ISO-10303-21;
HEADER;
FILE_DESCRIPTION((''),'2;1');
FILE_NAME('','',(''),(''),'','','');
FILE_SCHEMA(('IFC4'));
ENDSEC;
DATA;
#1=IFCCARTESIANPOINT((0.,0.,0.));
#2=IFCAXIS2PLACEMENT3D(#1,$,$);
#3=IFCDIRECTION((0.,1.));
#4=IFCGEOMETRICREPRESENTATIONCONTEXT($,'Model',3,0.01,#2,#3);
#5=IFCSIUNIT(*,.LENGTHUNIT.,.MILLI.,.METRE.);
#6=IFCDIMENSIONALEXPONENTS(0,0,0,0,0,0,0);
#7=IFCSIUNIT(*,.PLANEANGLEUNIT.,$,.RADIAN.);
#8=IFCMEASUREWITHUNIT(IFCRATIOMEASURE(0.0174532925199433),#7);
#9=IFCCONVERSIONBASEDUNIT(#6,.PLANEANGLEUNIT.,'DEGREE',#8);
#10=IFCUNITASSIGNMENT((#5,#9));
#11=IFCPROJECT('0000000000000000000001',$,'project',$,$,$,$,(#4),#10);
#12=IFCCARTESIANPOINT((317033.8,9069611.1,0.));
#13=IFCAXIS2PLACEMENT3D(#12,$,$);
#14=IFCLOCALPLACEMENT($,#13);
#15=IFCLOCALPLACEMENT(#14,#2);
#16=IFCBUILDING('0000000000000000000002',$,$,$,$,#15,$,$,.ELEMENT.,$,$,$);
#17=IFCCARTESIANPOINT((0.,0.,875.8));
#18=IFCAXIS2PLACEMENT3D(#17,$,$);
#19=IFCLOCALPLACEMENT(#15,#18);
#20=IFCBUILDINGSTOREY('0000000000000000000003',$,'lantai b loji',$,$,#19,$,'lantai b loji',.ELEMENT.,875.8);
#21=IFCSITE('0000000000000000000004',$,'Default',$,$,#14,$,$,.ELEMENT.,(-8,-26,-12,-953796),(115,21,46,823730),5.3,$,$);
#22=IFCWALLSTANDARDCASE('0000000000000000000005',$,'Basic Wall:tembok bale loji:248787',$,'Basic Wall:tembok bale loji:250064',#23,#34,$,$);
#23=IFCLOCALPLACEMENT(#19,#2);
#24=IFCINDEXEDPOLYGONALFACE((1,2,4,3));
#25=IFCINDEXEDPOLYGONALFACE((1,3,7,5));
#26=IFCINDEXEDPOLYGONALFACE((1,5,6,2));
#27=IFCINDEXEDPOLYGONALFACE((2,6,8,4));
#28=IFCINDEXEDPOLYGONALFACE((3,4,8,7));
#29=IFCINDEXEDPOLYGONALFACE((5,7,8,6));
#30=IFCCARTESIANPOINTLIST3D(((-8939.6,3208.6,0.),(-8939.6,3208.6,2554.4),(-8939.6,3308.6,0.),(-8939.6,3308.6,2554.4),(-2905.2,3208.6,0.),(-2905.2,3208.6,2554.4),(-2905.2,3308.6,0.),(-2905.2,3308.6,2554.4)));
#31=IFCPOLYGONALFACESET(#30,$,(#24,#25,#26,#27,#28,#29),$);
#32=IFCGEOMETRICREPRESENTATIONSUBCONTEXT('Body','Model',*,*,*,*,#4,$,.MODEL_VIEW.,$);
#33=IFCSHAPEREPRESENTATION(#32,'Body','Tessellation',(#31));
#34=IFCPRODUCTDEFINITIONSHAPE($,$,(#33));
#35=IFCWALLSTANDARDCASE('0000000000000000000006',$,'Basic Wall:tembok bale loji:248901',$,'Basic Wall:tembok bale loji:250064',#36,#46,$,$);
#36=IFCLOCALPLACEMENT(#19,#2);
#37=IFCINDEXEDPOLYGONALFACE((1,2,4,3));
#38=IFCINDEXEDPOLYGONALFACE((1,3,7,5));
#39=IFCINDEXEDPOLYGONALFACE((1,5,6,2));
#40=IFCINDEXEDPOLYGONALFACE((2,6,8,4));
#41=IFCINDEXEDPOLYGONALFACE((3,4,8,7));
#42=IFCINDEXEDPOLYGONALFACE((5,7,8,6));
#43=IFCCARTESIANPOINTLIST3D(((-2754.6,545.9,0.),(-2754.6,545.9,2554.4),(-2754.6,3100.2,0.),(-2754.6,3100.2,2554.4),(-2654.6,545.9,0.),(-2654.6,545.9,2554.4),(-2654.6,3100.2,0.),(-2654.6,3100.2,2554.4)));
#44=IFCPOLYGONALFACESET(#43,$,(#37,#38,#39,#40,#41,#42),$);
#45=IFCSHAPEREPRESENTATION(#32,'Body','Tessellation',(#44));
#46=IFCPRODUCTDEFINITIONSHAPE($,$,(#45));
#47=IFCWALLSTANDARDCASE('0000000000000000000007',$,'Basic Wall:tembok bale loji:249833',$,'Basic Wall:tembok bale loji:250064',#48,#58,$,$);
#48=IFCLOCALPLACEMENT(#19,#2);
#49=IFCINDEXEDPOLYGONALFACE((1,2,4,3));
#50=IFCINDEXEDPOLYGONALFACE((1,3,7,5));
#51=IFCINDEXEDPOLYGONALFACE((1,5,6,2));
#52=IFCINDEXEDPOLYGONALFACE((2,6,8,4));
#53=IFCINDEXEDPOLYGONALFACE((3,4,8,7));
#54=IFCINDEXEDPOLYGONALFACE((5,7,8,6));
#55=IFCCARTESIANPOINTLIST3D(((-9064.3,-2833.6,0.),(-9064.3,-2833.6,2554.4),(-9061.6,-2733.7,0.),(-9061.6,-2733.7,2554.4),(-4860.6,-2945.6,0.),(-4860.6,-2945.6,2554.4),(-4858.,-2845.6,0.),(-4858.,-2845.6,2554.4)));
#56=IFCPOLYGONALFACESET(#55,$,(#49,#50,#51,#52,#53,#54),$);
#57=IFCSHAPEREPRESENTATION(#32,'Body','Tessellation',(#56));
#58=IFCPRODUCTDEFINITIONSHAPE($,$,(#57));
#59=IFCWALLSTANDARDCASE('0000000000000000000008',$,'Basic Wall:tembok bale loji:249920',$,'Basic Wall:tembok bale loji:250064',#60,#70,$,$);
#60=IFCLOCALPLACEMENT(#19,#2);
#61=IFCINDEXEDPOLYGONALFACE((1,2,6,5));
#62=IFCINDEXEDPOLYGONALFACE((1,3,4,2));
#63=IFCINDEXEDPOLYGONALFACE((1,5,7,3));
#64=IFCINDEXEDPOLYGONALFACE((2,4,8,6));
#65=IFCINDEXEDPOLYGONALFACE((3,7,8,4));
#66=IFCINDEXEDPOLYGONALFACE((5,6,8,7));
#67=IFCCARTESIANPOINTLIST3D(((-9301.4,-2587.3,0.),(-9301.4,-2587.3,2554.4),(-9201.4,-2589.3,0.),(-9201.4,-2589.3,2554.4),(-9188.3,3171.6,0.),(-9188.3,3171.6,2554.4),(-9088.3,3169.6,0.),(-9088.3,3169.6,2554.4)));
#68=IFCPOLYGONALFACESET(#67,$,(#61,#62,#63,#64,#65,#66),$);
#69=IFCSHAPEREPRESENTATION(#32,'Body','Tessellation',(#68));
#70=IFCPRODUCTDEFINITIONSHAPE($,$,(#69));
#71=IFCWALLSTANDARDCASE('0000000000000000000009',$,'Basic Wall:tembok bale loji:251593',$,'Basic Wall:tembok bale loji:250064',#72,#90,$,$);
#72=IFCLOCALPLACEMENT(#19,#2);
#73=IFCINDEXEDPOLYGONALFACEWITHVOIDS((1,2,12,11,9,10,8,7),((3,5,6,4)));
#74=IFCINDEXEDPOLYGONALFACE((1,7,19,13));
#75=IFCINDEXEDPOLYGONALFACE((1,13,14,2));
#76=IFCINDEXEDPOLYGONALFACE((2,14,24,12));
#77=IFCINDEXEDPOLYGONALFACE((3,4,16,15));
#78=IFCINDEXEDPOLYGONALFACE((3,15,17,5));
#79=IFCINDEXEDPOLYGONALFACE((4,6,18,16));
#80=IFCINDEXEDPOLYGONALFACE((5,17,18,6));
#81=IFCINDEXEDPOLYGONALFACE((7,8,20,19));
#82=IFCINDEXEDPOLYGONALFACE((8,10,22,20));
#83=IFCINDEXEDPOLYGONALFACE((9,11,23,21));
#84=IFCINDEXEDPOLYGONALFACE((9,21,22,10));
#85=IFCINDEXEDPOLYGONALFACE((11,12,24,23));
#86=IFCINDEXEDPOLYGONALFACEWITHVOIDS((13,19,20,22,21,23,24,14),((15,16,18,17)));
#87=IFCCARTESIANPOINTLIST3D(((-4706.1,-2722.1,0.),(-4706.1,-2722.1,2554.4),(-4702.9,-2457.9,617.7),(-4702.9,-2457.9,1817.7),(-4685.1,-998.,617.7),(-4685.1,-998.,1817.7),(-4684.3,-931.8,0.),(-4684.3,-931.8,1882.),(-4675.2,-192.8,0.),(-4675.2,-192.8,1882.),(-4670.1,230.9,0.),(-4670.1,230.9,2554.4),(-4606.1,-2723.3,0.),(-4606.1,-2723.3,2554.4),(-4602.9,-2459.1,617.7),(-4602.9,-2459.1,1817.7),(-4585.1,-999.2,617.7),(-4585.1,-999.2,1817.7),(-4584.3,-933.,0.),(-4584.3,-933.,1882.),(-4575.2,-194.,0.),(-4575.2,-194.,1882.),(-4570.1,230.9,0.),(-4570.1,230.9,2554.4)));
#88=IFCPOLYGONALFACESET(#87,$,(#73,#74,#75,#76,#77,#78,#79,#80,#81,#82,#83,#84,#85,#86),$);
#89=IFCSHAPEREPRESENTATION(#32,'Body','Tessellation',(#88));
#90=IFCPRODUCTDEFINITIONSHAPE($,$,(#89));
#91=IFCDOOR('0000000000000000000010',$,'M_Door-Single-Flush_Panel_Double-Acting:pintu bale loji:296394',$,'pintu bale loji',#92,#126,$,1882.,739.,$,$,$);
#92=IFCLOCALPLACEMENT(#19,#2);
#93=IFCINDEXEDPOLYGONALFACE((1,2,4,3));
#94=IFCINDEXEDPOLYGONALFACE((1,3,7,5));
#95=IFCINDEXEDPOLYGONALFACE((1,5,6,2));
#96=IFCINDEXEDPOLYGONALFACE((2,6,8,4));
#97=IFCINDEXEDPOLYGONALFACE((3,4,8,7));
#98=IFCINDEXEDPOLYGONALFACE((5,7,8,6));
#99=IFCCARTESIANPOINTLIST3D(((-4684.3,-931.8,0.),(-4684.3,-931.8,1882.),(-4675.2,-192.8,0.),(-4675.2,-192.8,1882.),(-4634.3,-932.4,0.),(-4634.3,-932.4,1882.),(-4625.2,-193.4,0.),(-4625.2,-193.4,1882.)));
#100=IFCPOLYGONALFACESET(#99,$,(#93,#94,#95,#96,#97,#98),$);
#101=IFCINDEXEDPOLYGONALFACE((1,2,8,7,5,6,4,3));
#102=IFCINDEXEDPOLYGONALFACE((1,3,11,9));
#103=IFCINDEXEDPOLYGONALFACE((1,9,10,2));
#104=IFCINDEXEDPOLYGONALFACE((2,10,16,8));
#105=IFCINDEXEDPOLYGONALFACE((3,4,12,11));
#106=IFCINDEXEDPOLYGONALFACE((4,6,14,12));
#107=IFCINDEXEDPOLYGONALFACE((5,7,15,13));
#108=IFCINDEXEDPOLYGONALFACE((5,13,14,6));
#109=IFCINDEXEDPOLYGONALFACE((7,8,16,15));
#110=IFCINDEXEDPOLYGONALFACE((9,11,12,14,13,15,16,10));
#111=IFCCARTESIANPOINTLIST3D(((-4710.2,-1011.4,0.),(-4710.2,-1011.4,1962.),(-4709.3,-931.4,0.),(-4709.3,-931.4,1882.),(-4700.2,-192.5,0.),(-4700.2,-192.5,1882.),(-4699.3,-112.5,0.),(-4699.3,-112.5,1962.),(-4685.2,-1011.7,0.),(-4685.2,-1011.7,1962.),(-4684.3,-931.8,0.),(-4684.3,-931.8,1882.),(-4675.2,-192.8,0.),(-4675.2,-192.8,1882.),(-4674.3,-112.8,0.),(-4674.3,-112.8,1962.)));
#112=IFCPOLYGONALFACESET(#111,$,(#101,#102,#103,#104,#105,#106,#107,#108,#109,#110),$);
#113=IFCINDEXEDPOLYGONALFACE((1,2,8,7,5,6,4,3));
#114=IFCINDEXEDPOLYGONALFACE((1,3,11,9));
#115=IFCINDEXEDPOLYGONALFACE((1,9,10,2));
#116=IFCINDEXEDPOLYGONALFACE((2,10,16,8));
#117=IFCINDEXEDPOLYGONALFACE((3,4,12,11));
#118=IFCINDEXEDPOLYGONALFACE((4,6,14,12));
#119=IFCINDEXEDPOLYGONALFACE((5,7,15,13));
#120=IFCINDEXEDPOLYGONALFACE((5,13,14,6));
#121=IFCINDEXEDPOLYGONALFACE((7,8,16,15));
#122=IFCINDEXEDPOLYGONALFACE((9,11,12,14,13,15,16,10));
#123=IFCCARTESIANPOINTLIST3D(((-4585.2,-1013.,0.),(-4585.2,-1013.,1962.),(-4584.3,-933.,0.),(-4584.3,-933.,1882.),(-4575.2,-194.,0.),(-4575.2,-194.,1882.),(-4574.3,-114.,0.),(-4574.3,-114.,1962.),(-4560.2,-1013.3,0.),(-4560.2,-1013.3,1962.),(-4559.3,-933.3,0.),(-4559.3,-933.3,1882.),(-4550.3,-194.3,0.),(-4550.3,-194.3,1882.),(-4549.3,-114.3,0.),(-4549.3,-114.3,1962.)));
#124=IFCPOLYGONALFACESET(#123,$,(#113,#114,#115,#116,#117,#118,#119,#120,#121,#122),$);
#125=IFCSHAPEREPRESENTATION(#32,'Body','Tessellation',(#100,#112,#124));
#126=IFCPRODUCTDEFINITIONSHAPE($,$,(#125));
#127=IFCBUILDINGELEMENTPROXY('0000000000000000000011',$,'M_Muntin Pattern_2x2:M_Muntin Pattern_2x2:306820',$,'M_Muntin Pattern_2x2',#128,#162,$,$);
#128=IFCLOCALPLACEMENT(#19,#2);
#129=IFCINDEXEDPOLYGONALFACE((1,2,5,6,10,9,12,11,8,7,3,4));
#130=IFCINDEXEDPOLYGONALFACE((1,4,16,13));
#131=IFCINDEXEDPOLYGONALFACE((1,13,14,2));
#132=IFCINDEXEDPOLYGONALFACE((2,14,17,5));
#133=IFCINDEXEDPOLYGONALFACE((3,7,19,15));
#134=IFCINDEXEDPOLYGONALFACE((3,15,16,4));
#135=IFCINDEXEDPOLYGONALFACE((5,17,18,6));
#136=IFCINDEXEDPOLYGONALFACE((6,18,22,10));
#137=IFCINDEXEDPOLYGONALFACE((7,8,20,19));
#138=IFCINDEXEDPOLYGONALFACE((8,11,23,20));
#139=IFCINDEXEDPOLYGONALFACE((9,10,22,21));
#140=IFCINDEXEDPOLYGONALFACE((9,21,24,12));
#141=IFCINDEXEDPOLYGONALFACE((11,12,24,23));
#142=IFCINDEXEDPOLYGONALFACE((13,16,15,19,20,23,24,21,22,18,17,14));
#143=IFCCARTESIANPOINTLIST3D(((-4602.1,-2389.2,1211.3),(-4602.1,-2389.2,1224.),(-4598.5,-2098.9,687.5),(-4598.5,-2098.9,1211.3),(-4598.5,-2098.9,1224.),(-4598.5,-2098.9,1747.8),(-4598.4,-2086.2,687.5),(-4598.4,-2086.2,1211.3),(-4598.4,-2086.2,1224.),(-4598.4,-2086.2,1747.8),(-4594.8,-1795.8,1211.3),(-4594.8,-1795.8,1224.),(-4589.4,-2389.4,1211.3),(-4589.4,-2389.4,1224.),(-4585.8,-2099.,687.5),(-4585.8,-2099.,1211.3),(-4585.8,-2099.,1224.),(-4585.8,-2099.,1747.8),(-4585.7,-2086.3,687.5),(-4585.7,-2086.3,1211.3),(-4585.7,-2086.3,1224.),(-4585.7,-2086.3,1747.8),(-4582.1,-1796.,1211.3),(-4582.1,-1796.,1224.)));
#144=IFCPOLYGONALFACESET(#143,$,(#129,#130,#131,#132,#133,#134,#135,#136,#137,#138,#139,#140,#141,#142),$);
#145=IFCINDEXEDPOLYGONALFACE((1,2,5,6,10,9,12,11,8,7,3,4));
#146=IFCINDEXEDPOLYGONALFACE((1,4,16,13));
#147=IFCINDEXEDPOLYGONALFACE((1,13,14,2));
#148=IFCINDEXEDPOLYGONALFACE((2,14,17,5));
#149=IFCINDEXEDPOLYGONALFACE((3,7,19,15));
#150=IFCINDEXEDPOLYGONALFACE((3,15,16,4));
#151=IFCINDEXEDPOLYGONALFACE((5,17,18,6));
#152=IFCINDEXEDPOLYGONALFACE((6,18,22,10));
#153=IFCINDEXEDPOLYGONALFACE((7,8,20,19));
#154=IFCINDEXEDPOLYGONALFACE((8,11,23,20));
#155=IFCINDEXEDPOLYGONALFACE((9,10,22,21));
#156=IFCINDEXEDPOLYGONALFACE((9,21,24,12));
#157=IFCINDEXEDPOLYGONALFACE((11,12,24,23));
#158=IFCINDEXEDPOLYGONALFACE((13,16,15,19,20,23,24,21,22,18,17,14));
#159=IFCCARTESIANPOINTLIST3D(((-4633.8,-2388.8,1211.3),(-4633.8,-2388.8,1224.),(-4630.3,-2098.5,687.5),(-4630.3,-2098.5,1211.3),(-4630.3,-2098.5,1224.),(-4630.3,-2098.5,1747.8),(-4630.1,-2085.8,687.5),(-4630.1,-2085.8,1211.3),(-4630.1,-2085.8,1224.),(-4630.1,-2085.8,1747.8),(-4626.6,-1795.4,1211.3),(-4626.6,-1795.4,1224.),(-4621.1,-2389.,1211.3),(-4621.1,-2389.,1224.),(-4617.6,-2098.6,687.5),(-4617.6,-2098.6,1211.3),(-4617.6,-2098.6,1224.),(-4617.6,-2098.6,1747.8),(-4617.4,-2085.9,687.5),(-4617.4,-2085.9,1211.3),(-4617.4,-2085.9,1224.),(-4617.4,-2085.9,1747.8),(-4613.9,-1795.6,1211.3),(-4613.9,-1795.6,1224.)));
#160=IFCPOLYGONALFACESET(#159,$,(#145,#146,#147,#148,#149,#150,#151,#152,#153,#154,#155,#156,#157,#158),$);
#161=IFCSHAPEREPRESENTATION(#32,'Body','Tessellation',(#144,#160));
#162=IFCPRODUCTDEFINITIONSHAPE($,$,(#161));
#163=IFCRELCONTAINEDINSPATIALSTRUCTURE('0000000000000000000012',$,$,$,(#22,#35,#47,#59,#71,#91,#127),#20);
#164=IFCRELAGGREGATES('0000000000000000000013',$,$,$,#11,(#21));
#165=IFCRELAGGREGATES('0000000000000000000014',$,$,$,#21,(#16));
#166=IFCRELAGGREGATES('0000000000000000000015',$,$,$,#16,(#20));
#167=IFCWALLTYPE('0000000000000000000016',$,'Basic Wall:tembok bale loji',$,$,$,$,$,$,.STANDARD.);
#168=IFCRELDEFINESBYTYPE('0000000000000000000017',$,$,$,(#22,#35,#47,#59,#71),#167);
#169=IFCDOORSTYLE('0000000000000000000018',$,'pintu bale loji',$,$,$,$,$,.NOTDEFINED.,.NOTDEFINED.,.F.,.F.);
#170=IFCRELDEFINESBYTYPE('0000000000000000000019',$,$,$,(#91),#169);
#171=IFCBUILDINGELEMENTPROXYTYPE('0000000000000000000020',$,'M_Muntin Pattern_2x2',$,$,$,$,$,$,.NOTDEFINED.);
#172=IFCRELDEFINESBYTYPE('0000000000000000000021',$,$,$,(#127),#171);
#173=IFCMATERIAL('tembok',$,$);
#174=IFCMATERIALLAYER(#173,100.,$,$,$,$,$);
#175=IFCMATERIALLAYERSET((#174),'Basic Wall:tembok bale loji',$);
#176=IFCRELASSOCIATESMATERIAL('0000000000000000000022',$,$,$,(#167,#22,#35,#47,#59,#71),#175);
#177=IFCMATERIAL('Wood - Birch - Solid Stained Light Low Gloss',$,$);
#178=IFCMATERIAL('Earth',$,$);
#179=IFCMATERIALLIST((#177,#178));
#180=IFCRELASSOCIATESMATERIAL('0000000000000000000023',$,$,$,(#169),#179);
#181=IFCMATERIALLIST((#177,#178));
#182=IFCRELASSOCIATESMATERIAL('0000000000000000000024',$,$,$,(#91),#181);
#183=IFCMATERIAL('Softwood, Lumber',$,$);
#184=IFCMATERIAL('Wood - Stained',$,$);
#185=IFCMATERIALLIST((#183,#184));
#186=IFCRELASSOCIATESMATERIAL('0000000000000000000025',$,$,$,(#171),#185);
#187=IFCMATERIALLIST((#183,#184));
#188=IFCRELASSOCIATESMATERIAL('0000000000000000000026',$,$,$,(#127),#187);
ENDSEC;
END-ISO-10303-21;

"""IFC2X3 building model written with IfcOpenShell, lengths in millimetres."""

from ifc_helpers import new_model, entity, si_unit, converted_unit, direction, frame, frame_2d, origin, place, context, subcontext, project, spatial, polyline, rectangle, outline, extrude, source, transform, mapped, material, material_list, layer, layer_set, layer_usage, type_object, type_shapes, element, fill, save


model = new_model("IFC2X3")

# Units and contexts
model_context = context("Model", 3, precision=0.01, world=origin(), true_north=direction((0.0, 1.0)))
body_context = subcontext(model_context, "Body", "Model", "MODEL_VIEW")
ifc_project = project(units=[si_unit("LENGTHUNIT", "METRE", prefix="MILLI"), converted_unit("PLANEANGLEUNIT", "DEGREE", entity("IfcRatioMeasure", 0.0174532925199433), si_unit("PLANEANGLEUNIT", "RADIAN"), dimensions=[0, 0, 0, 0, 0, 0, 0])], contexts=[model_context])

# Site, building, storey
site_placement = place(None, frame((317033.8, 9069611.1, 0.0)))
site = spatial("IfcSite", under=ifc_project, at=site_placement, Name="Default", CompositionType="ELEMENT", RefLatitude=(-8, -26, -12, -953796), RefLongitude=(115, 21, 46, 823730), RefElevation=5.3)
building_placement = place(site_placement, origin())
building = spatial("IfcBuilding", under=site, at=building_placement, CompositionType="ELEMENT")
storey_placement = place(building_placement, frame((0.0, 0.0, 875.8)))
storey = spatial("IfcBuildingStorey", under=building, at=storey_placement, Name="lantai b loji", LongName="lantai b loji", CompositionType="ELEMENT", Elevation=875.8)

# Shared definitions
ifc_material_1 = material(Name="tembok")

# Walls
ifc_layer_1 = layer(ifc_material_1, 100.0)
ifc_layer_set_1 = layer_set([ifc_layer_1], Name="Basic Wall:tembok bale loji")
ifc_layer_usage_1 = layer_usage(ifc_layer_set_1, "AXIS2", "NEGATIVE", 50.0)
wall_type = type_object("IfcWallType", Name="Basic Wall:tembok bale loji", PredefinedType="STANDARD", material=ifc_layer_set_1)
wall_1_placement = place(storey_placement, frame((-8939.6, 3258.6, 0.0)))
element("IfcWallStandardCase", 1, at=wall_1_placement, inside=storey, type_object=wall_type, material=ifc_layer_usage_1, Name="Basic Wall:tembok bale loji:248787", ObjectType="Basic Wall:tembok bale loji:250064", context=body_context, shape_type="SweptSolid", body=[
    extrude(rectangle(XDim=6034.4, YDim=100.0, at=frame_2d((3017.2, 0.0), x_axis=(-1.0, 0.0))), origin(), (0.0, 0.0, 1.0), 2554.4),
])
ifc_layer_usage_2 = layer_usage(ifc_layer_set_1, "AXIS2", "NEGATIVE", 50.0)
wall_2_placement = place(storey_placement, frame((-2704.6, 3100.2, 0.0), z_axis=(0.0, 0.0, 1.0), x_axis=(0.0, -1.0, 0.0)))
element("IfcWallStandardCase", 2, at=wall_2_placement, inside=storey, type_object=wall_type, material=ifc_layer_usage_2, Name="Basic Wall:tembok bale loji:248901", ObjectType="Basic Wall:tembok bale loji:250064", context=body_context, shape_type="SweptSolid", body=[
    extrude(rectangle(XDim=2554.3, YDim=100.0, at=frame_2d((1277.1, 0.0), x_axis=(-1.0, 0.0))), origin(), (0.0, 0.0, 1.0), 2554.4),
])

# Shared definitions
ifc_material_2 = material(Name="Wood - Birch - Solid Stained Light Low Gloss")
ifc_material_3 = material(Name="Earth")
ifc_material_list_1 = material_list([ifc_material_2, ifc_material_3])
door_style = type_object("IfcDoorStyle", Name="pintu bale loji", ConstructionType="NOTDEFINED", OperationType="NOTDEFINED", ParameterTakesPrecedence=False, Sizeable=False, material=ifc_material_list_1)
shared_shape_1 = source(origin(), body_context, "Body", "SweptSolid", [
    extrude(rectangle(XDim=50.0, YDim=739.0, at=frame_2d((0.0, 0.0), x_axis=(1.0, 0.0))), frame((369.5, 75.0, 0.0), z_axis=(0.0, 0.0, 1.0), x_axis=(0.0, 1.0, 0.0)), (0.0, 0.0, 1.0), 1882.0),
    extrude(outline(polyline([(-449.5, -1001.0), (449.5, -1001.0), (449.5, 961.0), (369.5, 961.0), (369.5, -921.0), (-369.5, -921.0), (-369.5, 961.0), (-449.5, 961.0), (-449.5, -1001.0)])), frame((369.5, 100.0, 961.0), z_axis=(0.0, 1.0, 0.0), x_axis=(1.0, 0.0, 0.0)), (0.0, 0.0, 1.0), 25.0),
    extrude(outline(polyline([(-1001.0, -449.5), (961.0, -449.5), (961.0, -369.5), (-921.0, -369.5), (-921.0, 369.5), (961.0, 369.5), (961.0, 449.5), (-1001.0, 449.5), (-1001.0, -449.5)])), frame((369.5, -25.0, 961.0), z_axis=(0.0, 1.0, 0.0), x_axis=(0.0, 0.0, -1.0)), (0.0, 0.0, 1.0), 25.0),
])
type_shapes(door_style, [shared_shape_1])

# Walls
ifc_layer_usage_3 = layer_usage(ifc_layer_set_1, "AXIS2", "NEGATIVE", 50.0)
wall_3_placement = place(storey_placement, frame((-4859.3, -2895.6, 0.0), z_axis=(0.0, 0.0, 1.0), x_axis=(-0.999646, 0.02662, 0.0)))
element("IfcWallStandardCase", 3, at=wall_3_placement, inside=storey, type_object=wall_type, material=ifc_layer_usage_3, Name="Basic Wall:tembok bale loji:249833", ObjectType="Basic Wall:tembok bale loji:250064", context=body_context, shape_type="SweptSolid", body=[
    extrude(rectangle(XDim=4205.1, YDim=100.0, at=frame_2d((2102.6, 0.0), x_axis=(-1.0, 0.0))), origin(), (0.0, 0.0, 1.0), 2554.4),
])
ifc_layer_usage_4 = layer_usage(ifc_layer_set_1, "AXIS2", "NEGATIVE", 50.0)
wall_4_placement = place(storey_placement, frame((-9251.4, -2588.3, 0.0), z_axis=(0.0, 0.0, 1.0), x_axis=(0.019629, 0.999807, 0.0)))
element("IfcWallStandardCase", 4, at=wall_4_placement, inside=storey, type_object=wall_type, material=ifc_layer_usage_4, Name="Basic Wall:tembok bale loji:249920", ObjectType="Basic Wall:tembok bale loji:250064", context=body_context, shape_type="SweptSolid", body=[
    extrude(rectangle(XDim=5760.0, YDim=100.0, at=frame_2d((2880.0, 0.0), x_axis=(-1.0, 0.0))), origin(), (0.0, 0.0, 1.0), 2554.4),
])

# Wall, openings, door
ifc_layer_usage_5 = layer_usage(ifc_layer_set_1, "AXIS2", "NEGATIVE", 50.0)
wall_5_placement = place(storey_placement, frame((-4620.1, 231.5, 0.0), z_axis=(0.0, 0.0, 1.0), x_axis=(-0.012208, -0.999925, 0.0)))
wall_5 = element("IfcWallStandardCase", 5, at=wall_5_placement, inside=storey, type_object=wall_type, material=ifc_layer_usage_5, Name="Basic Wall:tembok bale loji:251593", ObjectType="Basic Wall:tembok bale loji:250064", context=body_context, shape_type="SweptSolid", body=[
    extrude(outline(polyline([(1.2, -50.0), (2954.5, -50.0), (2954.5, 50.0), (100.0, 50.0), (0.0, 50.0), (1.2, -50.0)])), origin(), (0.0, 0.0, 1.0), 2554.4),
])
opening_1_placement = place(wall_5_placement, frame((1164.0, 50.0, 0.0)))
opening_1 = element("IfcOpeningElement", 6, at=opening_1_placement, cuts=wall_5, ObjectType="Opening", context=body_context, shape_type="SweptSolid", body=[
    extrude(rectangle(XDim=739.0, YDim=1882.0, at=frame_2d((941.0, 369.5), x_axis=(0.0, 1.0))), frame((0.0, 0.0, 0.0), z_axis=(0.0, -1.0, 0.0), x_axis=(0.0, 0.0, 1.0)), (0.0, 0.0, 1.0), 100.0),
])
opening_2_placement = place(wall_5_placement, frame((1230.2, -50.0, 617.7)))
element("IfcOpeningElement", 7, at=opening_2_placement, cuts=wall_5, ObjectType="Opening", context=body_context, shape_type="SweptSolid", body=[
    extrude(rectangle(XDim=1200.0, YDim=1460.0, at=frame_2d((600.0, 730.0), x_axis=(-1.0, 0.0))), frame((0.0, 0.0, 0.0), z_axis=(0.0, 1.0, 0.0), x_axis=(0.0, 0.0, 1.0)), (0.0, 0.0, 1.0), 100.0),
])
ifc_material_list_2 = material_list([ifc_material_2, ifc_material_3])
door_1_placement = place(opening_1_placement, frame((0.0, 0.0, 0.0), z_axis=(0.0, 0.0, 1.0), x_axis=(-1.0, 0.0, 0.0)))
door_1 = element("IfcDoor", 8, at=door_1_placement, inside=storey, type_object=door_style, material=ifc_material_list_2, Name="M_Door-Single-Flush_Panel_Double-Acting:pintu bale loji:296394", ObjectType="pintu bale loji", OverallHeight=1882.0, OverallWidth=739.0, context=body_context, shape_type="MappedRepresentation", body=[
    mapped(shared_shape_1, transform((0.0, 0.0, 0.0), scale=1.0)),
])
fill(opening_1, door_1)

# Building element proxy
ifc_material_4 = material(Name="Softwood, Lumber")
ifc_material_5 = material(Name="Wood - Stained")
ifc_material_list_3 = material_list([ifc_material_4, ifc_material_5])
ifc_material_list_4 = material_list([ifc_material_4, ifc_material_5])
building_element_proxy_type_1 = type_object("IfcBuildingElementProxyType", Name="M_Muntin Pattern_2x2", PredefinedType="NOTDEFINED", material=ifc_material_list_4)
shared_shape_2 = source(origin(), body_context, "Body", "SweptSolid", [
    extrude(outline(polyline([(6.4, -6.4), (530.1, -6.4), (530.1, 6.3), (6.4, 6.3), (6.4, 296.7), (-6.3, 296.7), (-6.3, 6.3), (-530.2, 6.3), (-530.2, -6.4), (-6.3, -6.4), (-6.3, -296.7), (6.4, -296.7), (6.4, -6.4)])), frame((0.0, -22.2, 530.1), z_axis=(0.0, 1.0, 0.0), x_axis=(0.0, 0.0, 1.0)), (0.0, 0.0, 1.0), 12.7),
    extrude(outline(polyline([(6.4, -6.4), (530.2, -6.4), (530.2, 6.3), (6.4, 6.3), (6.4, 296.7), (-6.3, 296.7), (-6.3, 6.3), (-530.2, 6.3), (-530.2, -6.4), (-6.3, -6.4), (-6.3, -296.7), (6.4, -296.7), (6.4, -6.4)])), frame((0.0, 9.5, 530.2), z_axis=(0.0, 1.0, 0.0), x_axis=(0.0, 0.0, 1.0)), (0.0, 0.0, 1.0), 12.7),
])
type_shapes(building_element_proxy_type_1, [shared_shape_2])
proxy_1_placement = place(storey_placement, frame((-4608.0, -2092.4, 687.5), z_axis=(0.0, 0.0, 1.0), x_axis=(0.012208, 0.999925, 0.0)))
element("IfcBuildingElementProxy", 9, at=proxy_1_placement, inside=storey, type_object=building_element_proxy_type_1, material=ifc_material_list_3, Name="M_Muntin Pattern_2x2:M_Muntin Pattern_2x2:306820", ObjectType="M_Muntin Pattern_2x2", context=body_context, shape_type="MappedRepresentation", body=[
    mapped(shared_shape_2, transform((0.0, 0.0, 0.0), scale=1.0)),
])

save(model, "model.ifc")
